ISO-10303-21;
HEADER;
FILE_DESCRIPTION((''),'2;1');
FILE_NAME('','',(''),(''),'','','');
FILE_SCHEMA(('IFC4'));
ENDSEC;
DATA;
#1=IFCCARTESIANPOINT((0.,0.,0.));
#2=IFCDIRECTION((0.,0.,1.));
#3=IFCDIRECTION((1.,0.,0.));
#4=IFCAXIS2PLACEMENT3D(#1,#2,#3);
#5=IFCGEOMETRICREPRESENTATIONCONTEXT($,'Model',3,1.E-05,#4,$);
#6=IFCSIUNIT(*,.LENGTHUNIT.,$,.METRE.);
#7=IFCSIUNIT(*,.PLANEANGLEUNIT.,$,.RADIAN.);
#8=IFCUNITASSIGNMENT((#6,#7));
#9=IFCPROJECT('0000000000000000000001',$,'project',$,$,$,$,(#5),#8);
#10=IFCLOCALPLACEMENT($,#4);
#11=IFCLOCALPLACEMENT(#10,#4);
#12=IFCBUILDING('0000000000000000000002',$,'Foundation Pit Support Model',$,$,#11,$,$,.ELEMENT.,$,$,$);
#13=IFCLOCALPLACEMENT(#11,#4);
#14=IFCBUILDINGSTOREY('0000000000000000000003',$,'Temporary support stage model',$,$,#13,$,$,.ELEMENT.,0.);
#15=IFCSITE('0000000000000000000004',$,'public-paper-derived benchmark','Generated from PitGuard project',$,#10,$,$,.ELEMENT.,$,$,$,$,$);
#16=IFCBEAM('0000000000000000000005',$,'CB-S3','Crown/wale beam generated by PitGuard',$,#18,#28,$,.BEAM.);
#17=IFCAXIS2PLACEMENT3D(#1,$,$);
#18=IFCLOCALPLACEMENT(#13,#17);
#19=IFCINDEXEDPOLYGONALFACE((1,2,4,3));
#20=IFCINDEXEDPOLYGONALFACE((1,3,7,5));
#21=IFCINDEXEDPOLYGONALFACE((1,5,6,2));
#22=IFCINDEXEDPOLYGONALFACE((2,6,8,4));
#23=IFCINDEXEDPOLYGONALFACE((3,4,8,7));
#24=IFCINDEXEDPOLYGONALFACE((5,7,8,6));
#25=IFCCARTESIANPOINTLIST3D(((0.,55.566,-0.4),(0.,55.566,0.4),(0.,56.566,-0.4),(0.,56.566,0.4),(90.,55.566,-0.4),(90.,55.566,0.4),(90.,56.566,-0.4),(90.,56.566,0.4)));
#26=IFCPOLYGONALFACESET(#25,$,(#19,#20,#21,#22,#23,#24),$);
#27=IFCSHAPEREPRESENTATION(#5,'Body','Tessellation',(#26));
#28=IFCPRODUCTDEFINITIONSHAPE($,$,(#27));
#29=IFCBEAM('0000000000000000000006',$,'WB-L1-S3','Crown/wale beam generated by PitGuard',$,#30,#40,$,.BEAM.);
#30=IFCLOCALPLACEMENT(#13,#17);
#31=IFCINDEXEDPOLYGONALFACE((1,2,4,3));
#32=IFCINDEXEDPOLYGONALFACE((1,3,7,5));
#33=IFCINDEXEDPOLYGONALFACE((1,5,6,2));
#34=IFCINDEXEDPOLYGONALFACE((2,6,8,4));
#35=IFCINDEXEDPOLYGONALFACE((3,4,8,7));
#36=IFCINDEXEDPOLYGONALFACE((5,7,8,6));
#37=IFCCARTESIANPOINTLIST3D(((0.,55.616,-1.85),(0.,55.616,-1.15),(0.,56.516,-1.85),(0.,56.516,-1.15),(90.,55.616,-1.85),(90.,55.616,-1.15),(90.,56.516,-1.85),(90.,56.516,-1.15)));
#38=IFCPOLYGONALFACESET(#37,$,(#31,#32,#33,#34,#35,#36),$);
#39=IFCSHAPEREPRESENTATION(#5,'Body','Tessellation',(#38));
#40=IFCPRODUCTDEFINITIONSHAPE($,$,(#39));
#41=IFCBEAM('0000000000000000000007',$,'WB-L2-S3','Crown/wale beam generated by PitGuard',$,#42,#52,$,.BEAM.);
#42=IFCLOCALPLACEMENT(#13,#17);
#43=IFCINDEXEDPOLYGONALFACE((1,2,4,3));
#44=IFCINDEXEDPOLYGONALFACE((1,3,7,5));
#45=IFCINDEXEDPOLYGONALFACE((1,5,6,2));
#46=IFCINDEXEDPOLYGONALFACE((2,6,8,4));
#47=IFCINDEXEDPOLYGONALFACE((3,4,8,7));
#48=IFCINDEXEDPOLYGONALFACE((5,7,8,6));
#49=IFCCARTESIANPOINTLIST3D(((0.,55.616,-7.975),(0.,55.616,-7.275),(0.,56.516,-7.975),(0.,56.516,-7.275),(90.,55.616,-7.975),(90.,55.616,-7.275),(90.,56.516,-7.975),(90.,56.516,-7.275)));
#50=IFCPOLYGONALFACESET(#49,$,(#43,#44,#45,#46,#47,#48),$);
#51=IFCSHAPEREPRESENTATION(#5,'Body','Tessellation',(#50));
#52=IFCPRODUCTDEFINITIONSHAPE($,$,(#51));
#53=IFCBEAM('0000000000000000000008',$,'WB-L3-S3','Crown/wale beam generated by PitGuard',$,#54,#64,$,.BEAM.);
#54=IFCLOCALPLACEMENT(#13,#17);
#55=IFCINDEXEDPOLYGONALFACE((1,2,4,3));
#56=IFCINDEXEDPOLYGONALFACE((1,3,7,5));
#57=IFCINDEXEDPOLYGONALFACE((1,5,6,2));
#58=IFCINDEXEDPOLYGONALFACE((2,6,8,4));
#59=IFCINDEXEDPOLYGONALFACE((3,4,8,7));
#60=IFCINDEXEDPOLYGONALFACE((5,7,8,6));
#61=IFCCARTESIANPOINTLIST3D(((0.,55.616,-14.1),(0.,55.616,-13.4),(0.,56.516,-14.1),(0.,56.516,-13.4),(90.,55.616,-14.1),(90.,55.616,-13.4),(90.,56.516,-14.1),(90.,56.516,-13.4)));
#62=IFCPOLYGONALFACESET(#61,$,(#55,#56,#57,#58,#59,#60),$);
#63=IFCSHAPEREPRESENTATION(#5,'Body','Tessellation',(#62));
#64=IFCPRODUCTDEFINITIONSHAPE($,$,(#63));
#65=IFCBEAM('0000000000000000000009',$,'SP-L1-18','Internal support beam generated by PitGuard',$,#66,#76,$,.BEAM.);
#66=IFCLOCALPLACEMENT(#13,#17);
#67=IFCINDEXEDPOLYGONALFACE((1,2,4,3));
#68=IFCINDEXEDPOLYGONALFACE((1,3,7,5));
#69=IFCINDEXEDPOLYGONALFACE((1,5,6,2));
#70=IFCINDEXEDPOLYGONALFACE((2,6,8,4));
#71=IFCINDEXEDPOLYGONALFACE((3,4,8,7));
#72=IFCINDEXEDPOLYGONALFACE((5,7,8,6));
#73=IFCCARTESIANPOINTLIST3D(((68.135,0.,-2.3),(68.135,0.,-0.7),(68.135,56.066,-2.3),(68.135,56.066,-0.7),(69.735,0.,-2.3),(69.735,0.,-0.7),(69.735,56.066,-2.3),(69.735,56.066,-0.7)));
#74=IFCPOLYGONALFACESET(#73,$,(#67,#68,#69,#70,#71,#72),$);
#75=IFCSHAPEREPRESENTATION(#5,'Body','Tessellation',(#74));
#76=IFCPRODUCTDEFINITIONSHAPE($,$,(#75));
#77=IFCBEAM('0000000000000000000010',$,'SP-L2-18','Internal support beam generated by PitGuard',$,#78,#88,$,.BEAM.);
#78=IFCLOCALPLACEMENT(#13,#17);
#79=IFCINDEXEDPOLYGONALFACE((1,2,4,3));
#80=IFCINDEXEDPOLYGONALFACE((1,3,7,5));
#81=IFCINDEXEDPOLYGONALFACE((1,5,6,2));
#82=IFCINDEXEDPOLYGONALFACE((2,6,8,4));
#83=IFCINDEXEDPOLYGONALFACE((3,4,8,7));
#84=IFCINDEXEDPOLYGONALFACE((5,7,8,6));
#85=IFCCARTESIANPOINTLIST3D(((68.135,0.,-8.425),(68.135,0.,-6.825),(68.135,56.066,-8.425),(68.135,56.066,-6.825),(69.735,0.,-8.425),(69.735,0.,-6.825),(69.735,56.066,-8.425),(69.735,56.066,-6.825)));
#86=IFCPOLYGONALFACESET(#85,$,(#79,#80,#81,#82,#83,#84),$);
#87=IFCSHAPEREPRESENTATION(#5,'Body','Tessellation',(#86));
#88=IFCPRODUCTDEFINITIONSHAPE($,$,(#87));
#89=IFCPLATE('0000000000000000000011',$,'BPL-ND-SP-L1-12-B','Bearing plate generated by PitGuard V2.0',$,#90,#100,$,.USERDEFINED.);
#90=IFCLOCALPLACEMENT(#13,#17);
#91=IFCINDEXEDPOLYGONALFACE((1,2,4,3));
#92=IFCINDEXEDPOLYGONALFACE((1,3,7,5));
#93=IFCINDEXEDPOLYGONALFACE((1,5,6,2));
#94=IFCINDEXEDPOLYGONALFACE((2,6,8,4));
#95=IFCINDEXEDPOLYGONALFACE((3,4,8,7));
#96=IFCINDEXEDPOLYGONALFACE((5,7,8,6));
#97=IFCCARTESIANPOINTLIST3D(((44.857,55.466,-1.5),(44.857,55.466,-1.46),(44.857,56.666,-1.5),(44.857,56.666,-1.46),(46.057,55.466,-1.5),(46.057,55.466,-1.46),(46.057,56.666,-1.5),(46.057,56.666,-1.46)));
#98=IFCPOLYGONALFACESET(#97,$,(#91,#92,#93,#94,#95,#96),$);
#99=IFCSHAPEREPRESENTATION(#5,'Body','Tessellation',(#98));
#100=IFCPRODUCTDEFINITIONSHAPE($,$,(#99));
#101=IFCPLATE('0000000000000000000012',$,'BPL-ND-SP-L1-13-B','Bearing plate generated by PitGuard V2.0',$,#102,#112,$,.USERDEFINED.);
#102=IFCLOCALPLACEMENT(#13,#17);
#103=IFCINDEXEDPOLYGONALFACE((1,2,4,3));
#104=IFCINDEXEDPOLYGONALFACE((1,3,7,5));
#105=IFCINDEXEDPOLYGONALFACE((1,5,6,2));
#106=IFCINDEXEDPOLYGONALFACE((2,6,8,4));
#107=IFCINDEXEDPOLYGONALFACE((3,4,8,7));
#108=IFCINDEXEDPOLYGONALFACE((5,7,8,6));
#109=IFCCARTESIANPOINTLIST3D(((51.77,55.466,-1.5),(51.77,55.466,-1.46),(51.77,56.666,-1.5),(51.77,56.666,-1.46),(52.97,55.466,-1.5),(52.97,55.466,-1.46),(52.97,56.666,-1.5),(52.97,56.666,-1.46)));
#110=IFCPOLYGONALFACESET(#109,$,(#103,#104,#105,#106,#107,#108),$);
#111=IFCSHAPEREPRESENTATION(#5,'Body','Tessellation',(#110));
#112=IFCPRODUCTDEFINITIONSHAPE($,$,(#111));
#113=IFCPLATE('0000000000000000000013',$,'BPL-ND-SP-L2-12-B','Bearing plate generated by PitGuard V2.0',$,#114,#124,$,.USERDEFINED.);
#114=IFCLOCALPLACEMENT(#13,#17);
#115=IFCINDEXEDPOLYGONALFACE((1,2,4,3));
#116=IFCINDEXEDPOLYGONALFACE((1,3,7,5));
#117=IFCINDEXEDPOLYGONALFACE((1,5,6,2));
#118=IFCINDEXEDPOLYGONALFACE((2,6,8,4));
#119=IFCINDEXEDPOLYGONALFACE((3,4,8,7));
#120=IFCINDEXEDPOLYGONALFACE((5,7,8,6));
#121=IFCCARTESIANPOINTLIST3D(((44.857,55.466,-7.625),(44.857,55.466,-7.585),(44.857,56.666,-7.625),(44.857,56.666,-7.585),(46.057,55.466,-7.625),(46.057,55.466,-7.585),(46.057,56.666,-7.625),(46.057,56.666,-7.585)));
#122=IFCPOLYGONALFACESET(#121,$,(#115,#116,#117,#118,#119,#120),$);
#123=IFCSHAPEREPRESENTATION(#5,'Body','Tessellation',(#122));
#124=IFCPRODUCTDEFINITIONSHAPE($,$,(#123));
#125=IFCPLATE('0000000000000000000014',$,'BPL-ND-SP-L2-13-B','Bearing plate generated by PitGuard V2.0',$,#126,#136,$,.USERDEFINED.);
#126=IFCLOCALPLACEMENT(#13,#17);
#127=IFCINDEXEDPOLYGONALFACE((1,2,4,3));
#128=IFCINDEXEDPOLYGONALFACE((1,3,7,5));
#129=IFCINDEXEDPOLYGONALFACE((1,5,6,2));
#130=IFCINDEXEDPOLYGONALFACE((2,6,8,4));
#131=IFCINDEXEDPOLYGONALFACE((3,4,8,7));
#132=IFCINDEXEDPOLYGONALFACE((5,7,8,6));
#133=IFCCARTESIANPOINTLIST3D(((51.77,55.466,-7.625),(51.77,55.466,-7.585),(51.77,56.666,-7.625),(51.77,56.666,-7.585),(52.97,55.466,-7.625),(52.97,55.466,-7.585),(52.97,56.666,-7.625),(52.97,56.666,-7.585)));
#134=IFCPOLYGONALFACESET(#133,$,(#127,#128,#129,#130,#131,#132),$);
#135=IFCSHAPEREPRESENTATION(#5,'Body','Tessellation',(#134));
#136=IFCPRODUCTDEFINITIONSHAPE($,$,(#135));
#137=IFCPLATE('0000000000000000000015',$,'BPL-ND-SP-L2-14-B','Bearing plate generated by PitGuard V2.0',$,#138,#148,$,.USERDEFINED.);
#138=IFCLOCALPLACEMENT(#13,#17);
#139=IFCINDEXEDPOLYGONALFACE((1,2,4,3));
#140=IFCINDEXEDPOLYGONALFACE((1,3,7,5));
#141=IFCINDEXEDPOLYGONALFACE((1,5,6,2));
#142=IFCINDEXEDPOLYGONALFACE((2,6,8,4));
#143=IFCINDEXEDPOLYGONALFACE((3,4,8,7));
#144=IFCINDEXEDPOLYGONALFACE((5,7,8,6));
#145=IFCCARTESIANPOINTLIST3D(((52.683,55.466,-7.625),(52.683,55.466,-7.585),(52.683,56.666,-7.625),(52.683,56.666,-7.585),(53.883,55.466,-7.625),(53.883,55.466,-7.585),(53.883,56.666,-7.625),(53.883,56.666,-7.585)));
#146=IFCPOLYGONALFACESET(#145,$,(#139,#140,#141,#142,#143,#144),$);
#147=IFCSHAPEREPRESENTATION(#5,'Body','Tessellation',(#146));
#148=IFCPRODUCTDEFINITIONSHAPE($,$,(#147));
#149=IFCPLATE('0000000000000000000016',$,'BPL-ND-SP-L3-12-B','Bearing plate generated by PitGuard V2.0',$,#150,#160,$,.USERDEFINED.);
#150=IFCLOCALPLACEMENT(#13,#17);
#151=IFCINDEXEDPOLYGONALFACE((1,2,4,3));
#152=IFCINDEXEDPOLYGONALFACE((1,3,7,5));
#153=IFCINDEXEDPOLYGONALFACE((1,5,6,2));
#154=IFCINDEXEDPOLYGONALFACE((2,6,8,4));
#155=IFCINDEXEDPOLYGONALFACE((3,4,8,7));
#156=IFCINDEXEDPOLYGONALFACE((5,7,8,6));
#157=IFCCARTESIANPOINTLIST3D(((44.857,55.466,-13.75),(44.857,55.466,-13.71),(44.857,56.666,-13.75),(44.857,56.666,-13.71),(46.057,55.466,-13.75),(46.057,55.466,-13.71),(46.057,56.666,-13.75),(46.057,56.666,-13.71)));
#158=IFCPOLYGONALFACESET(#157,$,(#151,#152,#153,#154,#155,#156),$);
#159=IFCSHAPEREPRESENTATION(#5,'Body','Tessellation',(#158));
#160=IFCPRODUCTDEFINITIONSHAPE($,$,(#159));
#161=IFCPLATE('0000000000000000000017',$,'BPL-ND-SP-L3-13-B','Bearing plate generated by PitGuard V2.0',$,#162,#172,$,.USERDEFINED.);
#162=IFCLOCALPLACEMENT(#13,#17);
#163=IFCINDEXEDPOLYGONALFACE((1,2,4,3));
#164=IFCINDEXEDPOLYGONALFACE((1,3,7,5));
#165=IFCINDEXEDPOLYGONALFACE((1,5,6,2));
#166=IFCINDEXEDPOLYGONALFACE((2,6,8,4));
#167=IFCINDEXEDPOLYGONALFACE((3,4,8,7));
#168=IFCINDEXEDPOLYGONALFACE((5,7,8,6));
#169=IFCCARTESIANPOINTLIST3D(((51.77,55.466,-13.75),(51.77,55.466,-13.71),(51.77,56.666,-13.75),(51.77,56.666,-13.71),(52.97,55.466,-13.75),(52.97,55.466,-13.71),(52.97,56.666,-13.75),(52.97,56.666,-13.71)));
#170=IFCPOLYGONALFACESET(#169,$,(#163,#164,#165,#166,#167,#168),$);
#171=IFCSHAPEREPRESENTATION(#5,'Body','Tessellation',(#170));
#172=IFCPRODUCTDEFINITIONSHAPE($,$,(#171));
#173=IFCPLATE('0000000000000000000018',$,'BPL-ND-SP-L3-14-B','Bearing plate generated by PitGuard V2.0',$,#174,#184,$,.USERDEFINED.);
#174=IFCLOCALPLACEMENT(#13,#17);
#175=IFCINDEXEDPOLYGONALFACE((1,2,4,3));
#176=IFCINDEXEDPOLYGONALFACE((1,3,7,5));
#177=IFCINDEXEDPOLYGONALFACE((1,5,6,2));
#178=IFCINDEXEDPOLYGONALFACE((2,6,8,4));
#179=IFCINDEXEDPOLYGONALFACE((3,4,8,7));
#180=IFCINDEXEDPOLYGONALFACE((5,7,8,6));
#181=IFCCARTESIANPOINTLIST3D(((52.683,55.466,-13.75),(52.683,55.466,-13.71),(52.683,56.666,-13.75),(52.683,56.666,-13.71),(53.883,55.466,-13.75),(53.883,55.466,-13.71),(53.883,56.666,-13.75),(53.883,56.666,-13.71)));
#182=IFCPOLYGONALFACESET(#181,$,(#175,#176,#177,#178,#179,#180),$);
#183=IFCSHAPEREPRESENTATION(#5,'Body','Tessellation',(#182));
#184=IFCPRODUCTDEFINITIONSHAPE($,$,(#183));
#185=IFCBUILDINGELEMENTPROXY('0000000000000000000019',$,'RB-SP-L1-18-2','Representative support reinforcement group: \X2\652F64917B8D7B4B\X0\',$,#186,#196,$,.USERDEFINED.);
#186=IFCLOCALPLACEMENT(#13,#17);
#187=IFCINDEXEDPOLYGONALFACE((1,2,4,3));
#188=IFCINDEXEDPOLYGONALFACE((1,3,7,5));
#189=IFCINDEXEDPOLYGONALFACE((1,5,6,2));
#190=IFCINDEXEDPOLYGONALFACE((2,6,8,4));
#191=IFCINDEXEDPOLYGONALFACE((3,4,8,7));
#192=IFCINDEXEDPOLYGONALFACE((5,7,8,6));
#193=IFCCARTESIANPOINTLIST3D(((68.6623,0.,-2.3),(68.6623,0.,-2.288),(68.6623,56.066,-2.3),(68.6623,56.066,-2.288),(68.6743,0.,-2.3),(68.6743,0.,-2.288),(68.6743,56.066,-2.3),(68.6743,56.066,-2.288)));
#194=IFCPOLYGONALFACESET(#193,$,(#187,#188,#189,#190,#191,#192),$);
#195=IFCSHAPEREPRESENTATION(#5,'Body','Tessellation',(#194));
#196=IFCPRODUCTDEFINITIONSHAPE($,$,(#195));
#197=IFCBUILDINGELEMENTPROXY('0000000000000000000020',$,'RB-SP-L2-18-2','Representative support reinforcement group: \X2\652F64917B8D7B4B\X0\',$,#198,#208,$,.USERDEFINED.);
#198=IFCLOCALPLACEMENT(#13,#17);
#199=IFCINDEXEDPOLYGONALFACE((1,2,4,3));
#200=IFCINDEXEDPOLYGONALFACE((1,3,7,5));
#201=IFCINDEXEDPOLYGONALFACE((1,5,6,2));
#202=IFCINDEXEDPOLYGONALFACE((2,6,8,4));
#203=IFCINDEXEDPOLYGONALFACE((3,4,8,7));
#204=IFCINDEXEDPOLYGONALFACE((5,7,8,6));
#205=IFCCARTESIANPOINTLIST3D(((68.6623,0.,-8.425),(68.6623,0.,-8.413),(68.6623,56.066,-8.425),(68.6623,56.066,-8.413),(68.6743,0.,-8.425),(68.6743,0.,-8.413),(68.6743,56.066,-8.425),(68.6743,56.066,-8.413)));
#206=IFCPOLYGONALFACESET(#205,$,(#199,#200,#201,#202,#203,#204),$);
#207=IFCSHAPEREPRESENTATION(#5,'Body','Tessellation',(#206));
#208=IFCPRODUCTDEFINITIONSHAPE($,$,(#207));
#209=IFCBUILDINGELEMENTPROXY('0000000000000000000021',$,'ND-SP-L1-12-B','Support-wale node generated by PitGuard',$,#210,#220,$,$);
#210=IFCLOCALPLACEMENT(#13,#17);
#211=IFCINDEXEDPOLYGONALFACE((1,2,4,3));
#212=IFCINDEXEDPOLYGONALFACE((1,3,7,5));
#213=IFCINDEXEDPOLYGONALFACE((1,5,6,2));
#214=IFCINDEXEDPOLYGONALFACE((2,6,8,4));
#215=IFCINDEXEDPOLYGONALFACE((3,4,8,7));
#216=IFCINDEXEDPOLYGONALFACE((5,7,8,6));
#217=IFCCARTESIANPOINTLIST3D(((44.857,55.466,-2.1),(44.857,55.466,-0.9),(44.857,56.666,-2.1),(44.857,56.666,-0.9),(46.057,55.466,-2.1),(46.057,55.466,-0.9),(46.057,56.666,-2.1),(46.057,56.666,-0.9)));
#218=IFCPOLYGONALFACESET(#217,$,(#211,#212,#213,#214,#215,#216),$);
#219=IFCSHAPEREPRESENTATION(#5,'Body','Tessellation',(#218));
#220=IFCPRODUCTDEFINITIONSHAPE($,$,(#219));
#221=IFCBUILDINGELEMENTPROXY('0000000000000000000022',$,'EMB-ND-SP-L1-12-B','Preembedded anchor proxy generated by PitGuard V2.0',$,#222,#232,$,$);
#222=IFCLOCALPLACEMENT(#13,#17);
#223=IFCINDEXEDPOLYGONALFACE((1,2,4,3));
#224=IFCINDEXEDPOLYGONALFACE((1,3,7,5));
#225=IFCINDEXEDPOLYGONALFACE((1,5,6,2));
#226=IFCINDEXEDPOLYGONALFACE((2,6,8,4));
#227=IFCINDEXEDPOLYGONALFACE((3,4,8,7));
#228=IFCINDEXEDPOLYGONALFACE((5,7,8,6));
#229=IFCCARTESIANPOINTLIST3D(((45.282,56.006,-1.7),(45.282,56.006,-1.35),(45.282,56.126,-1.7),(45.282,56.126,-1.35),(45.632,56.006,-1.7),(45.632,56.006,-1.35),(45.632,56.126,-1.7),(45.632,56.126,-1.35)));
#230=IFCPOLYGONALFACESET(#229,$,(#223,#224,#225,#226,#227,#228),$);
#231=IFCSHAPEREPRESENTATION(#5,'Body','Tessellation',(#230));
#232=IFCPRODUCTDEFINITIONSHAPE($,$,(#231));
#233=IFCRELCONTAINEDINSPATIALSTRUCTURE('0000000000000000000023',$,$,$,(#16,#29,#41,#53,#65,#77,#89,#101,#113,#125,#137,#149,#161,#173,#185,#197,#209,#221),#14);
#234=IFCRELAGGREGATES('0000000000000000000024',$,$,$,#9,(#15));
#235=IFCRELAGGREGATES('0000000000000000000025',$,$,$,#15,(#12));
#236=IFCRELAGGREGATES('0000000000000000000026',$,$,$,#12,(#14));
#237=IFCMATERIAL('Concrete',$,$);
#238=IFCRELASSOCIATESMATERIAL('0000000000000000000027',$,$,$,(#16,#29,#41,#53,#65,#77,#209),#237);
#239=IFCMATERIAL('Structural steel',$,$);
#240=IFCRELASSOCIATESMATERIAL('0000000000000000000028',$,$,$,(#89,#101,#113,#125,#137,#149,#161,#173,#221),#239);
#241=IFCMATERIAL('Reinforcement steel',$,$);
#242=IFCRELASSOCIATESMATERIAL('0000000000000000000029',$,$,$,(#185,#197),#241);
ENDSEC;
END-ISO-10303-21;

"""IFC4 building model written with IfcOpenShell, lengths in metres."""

from ifc_helpers import new_model, si_unit, frame, origin_with_axes, origin_2d, place, context, project, spatial, rectangle, extrude, material, element, save


model = new_model("IFC4")

# Units and contexts
model_context = context("Model", 3, precision=1e-05, world=origin_with_axes())
ifc_project = project(units=[si_unit("LENGTHUNIT", "METRE"), si_unit("PLANEANGLEUNIT", "RADIAN")], contexts=[model_context])

# Site, building, storey
site_placement = place(None, origin_with_axes())
site = spatial("IfcSite", under=ifc_project, at=site_placement, Name="public-paper-derived benchmark", Description="Generated from PitGuard project", CompositionType="ELEMENT")
building_placement = place(site_placement, origin_with_axes())
building = spatial("IfcBuilding", under=site, at=building_placement, Name="Foundation Pit Support Model", CompositionType="ELEMENT")
storey_placement = place(building_placement, origin_with_axes())
storey = spatial("IfcBuildingStorey", under=building, at=storey_placement, Name="Temporary support stage model", CompositionType="ELEMENT", Elevation=0.0)

# Beams
ifc_material_1 = material(Name="Concrete")
beam_placement = place(storey_placement, frame((45.0, 56.066, -0.4), z_axis=(0.0, 0.0, 1.0), x_axis=(-1.0, 0.0, 0.0)))
element("IfcBeam", 1, at=beam_placement, inside=storey, material=ifc_material_1, Name="CB-S3", Description="Crown/wale beam generated by PitGuard", PredefinedType="BEAM", context=model_context, shape_type="SweptSolid", body=[
    extrude(rectangle(XDim=90.0, YDim=1.0, at=origin_2d()), origin_with_axes(), (0.0, 0.0, 1.0), 0.8),
])
for number, where, z_axis, x_axis, name in (
    (2, (45.0, 56.066, -1.85), (0.0, 0.0, 1.0), (-1.0, 0.0, 0.0), "WB-L1-S3"),
    (3, (45.0, 56.066, -7.975), (0.0, 0.0, 1.0), (-1.0, 0.0, 0.0), "WB-L2-S3"),
    (4, (45.0, 56.066, -14.1), (0.0, 0.0, 1.0), (-1.0, 0.0, 0.0), "WB-L3-S3"),
):
    element("IfcBeam", number, at=place(storey_placement, frame(where, z_axis=z_axis, x_axis=x_axis)), inside=storey, material=ifc_material_1, Name=name, Description="Crown/wale beam generated by PitGuard", PredefinedType="BEAM", context=model_context, shape_type="SweptSolid", body=[
        extrude(rectangle(XDim=90.0, YDim=0.9, at=origin_2d()), origin_with_axes(), (0.0, 0.0, 1.0), 0.7),
    ])
for number, where, z_axis, x_axis, name in (
    (5, (68.935, 28.033, -2.3), (0.0, 0.0, 1.0), (0.0, 1.0, 0.0), "SP-L1-18"),
    (6, (68.935, 28.033, -8.425), (0.0, 0.0, 1.0), (0.0, 1.0, 0.0), "SP-L2-18"),
):
    element("IfcBeam", number, at=place(storey_placement, frame(where, z_axis=z_axis, x_axis=x_axis)), inside=storey, material=ifc_material_1, Name=name, Description="Internal support beam generated by PitGuard", PredefinedType="BEAM", context=model_context, shape_type="SweptSolid", body=[
        extrude(rectangle(XDim=56.066, YDim=1.6, at=origin_2d()), origin_with_axes(), (0.0, 0.0, 1.0), 1.6),
    ])

# Plates
ifc_material_2 = material(Name="Structural steel")
for number, where, z_axis, x_axis, name in (
    (7, (45.457, 56.066, -1.5), (0.0, 0.0, 1.0), (1.0, 0.0, 0.0), "BPL-ND-SP-L1-12-B"),
    (8, (52.37, 56.066, -1.5), (0.0, 0.0, 1.0), (1.0, 0.0, 0.0), "BPL-ND-SP-L1-13-B"),
    (9, (45.457, 56.066, -7.625), (0.0, 0.0, 1.0), (1.0, 0.0, 0.0), "BPL-ND-SP-L2-12-B"),
    (10, (52.37, 56.066, -7.625), (0.0, 0.0, 1.0), (1.0, 0.0, 0.0), "BPL-ND-SP-L2-13-B"),
    (11, (53.283, 56.066, -7.625), (0.0, 0.0, 1.0), (1.0, 0.0, 0.0), "BPL-ND-SP-L2-14-B"),
    (12, (45.457, 56.066, -13.75), (0.0, 0.0, 1.0), (1.0, 0.0, 0.0), "BPL-ND-SP-L3-12-B"),
    (13, (52.37, 56.066, -13.75), (0.0, 0.0, 1.0), (1.0, 0.0, 0.0), "BPL-ND-SP-L3-13-B"),
    (14, (53.283, 56.066, -13.75), (0.0, 0.0, 1.0), (1.0, 0.0, 0.0), "BPL-ND-SP-L3-14-B"),
):
    element("IfcPlate", number, at=place(storey_placement, frame(where, z_axis=z_axis, x_axis=x_axis)), inside=storey, material=ifc_material_2, Name=name, Description="Bearing plate generated by PitGuard V2.0", PredefinedType="USERDEFINED", context=model_context, shape_type="SweptSolid", body=[
        extrude(rectangle(XDim=1.2, YDim=1.2, at=origin_2d()), origin_with_axes(), (0.0, 0.0, 1.0), 0.04),
    ])

# Building element proxies
ifc_material_3 = material(Name="Reinforcement steel")
for number, where, z_axis, x_axis, name in (
    (15, (68.6683, 28.033, -2.3), (0.0, 0.0, 1.0), (0.0, 1.0, 0.0), "RB-SP-L1-18-2"),
    (16, (68.6683, 28.033, -8.425), (0.0, 0.0, 1.0), (0.0, 1.0, 0.0), "RB-SP-L2-18-2"),
):
    element("IfcBuildingElementProxy", number, at=place(storey_placement, frame(where, z_axis=z_axis, x_axis=x_axis)), inside=storey, material=ifc_material_3, Name=name, Description="Representative support reinforcement group: 支撑箍筋", PredefinedType="USERDEFINED", context=model_context, shape_type="SweptSolid", body=[
        extrude(rectangle(XDim=56.066, YDim=0.012, at=origin_2d()), origin_with_axes(), (0.0, 0.0, 1.0), 0.012),
    ])
proxy_1_placement = place(storey_placement, frame((45.457, 56.066, -2.1), z_axis=(0.0, 0.0, 1.0), x_axis=(1.0, 0.0, 0.0)))
element("IfcBuildingElementProxy", 17, at=proxy_1_placement, inside=storey, material=ifc_material_1, Name="ND-SP-L1-12-B", Description="Support-wale node generated by PitGuard", context=model_context, shape_type="SweptSolid", body=[
    extrude(rectangle(XDim=1.2, YDim=1.2, at=origin_2d()), origin_with_axes(), (0.0, 0.0, 1.0), 1.2),
])
proxy_2_placement = place(storey_placement, frame((45.457, 56.066, -1.7), z_axis=(0.0, 0.0, 1.0), x_axis=(1.0, 0.0, 0.0)))
element("IfcBuildingElementProxy", 18, at=proxy_2_placement, inside=storey, material=ifc_material_2, Name="EMB-ND-SP-L1-12-B", Description="Preembedded anchor proxy generated by PitGuard V2.0", context=model_context, shape_type="SweptSolid", body=[
    extrude(rectangle(XDim=0.35, YDim=0.12, at=origin_2d()), origin_with_axes(), (0.0, 0.0, 1.0), 0.35),
])

save(model, "model.ifc")
